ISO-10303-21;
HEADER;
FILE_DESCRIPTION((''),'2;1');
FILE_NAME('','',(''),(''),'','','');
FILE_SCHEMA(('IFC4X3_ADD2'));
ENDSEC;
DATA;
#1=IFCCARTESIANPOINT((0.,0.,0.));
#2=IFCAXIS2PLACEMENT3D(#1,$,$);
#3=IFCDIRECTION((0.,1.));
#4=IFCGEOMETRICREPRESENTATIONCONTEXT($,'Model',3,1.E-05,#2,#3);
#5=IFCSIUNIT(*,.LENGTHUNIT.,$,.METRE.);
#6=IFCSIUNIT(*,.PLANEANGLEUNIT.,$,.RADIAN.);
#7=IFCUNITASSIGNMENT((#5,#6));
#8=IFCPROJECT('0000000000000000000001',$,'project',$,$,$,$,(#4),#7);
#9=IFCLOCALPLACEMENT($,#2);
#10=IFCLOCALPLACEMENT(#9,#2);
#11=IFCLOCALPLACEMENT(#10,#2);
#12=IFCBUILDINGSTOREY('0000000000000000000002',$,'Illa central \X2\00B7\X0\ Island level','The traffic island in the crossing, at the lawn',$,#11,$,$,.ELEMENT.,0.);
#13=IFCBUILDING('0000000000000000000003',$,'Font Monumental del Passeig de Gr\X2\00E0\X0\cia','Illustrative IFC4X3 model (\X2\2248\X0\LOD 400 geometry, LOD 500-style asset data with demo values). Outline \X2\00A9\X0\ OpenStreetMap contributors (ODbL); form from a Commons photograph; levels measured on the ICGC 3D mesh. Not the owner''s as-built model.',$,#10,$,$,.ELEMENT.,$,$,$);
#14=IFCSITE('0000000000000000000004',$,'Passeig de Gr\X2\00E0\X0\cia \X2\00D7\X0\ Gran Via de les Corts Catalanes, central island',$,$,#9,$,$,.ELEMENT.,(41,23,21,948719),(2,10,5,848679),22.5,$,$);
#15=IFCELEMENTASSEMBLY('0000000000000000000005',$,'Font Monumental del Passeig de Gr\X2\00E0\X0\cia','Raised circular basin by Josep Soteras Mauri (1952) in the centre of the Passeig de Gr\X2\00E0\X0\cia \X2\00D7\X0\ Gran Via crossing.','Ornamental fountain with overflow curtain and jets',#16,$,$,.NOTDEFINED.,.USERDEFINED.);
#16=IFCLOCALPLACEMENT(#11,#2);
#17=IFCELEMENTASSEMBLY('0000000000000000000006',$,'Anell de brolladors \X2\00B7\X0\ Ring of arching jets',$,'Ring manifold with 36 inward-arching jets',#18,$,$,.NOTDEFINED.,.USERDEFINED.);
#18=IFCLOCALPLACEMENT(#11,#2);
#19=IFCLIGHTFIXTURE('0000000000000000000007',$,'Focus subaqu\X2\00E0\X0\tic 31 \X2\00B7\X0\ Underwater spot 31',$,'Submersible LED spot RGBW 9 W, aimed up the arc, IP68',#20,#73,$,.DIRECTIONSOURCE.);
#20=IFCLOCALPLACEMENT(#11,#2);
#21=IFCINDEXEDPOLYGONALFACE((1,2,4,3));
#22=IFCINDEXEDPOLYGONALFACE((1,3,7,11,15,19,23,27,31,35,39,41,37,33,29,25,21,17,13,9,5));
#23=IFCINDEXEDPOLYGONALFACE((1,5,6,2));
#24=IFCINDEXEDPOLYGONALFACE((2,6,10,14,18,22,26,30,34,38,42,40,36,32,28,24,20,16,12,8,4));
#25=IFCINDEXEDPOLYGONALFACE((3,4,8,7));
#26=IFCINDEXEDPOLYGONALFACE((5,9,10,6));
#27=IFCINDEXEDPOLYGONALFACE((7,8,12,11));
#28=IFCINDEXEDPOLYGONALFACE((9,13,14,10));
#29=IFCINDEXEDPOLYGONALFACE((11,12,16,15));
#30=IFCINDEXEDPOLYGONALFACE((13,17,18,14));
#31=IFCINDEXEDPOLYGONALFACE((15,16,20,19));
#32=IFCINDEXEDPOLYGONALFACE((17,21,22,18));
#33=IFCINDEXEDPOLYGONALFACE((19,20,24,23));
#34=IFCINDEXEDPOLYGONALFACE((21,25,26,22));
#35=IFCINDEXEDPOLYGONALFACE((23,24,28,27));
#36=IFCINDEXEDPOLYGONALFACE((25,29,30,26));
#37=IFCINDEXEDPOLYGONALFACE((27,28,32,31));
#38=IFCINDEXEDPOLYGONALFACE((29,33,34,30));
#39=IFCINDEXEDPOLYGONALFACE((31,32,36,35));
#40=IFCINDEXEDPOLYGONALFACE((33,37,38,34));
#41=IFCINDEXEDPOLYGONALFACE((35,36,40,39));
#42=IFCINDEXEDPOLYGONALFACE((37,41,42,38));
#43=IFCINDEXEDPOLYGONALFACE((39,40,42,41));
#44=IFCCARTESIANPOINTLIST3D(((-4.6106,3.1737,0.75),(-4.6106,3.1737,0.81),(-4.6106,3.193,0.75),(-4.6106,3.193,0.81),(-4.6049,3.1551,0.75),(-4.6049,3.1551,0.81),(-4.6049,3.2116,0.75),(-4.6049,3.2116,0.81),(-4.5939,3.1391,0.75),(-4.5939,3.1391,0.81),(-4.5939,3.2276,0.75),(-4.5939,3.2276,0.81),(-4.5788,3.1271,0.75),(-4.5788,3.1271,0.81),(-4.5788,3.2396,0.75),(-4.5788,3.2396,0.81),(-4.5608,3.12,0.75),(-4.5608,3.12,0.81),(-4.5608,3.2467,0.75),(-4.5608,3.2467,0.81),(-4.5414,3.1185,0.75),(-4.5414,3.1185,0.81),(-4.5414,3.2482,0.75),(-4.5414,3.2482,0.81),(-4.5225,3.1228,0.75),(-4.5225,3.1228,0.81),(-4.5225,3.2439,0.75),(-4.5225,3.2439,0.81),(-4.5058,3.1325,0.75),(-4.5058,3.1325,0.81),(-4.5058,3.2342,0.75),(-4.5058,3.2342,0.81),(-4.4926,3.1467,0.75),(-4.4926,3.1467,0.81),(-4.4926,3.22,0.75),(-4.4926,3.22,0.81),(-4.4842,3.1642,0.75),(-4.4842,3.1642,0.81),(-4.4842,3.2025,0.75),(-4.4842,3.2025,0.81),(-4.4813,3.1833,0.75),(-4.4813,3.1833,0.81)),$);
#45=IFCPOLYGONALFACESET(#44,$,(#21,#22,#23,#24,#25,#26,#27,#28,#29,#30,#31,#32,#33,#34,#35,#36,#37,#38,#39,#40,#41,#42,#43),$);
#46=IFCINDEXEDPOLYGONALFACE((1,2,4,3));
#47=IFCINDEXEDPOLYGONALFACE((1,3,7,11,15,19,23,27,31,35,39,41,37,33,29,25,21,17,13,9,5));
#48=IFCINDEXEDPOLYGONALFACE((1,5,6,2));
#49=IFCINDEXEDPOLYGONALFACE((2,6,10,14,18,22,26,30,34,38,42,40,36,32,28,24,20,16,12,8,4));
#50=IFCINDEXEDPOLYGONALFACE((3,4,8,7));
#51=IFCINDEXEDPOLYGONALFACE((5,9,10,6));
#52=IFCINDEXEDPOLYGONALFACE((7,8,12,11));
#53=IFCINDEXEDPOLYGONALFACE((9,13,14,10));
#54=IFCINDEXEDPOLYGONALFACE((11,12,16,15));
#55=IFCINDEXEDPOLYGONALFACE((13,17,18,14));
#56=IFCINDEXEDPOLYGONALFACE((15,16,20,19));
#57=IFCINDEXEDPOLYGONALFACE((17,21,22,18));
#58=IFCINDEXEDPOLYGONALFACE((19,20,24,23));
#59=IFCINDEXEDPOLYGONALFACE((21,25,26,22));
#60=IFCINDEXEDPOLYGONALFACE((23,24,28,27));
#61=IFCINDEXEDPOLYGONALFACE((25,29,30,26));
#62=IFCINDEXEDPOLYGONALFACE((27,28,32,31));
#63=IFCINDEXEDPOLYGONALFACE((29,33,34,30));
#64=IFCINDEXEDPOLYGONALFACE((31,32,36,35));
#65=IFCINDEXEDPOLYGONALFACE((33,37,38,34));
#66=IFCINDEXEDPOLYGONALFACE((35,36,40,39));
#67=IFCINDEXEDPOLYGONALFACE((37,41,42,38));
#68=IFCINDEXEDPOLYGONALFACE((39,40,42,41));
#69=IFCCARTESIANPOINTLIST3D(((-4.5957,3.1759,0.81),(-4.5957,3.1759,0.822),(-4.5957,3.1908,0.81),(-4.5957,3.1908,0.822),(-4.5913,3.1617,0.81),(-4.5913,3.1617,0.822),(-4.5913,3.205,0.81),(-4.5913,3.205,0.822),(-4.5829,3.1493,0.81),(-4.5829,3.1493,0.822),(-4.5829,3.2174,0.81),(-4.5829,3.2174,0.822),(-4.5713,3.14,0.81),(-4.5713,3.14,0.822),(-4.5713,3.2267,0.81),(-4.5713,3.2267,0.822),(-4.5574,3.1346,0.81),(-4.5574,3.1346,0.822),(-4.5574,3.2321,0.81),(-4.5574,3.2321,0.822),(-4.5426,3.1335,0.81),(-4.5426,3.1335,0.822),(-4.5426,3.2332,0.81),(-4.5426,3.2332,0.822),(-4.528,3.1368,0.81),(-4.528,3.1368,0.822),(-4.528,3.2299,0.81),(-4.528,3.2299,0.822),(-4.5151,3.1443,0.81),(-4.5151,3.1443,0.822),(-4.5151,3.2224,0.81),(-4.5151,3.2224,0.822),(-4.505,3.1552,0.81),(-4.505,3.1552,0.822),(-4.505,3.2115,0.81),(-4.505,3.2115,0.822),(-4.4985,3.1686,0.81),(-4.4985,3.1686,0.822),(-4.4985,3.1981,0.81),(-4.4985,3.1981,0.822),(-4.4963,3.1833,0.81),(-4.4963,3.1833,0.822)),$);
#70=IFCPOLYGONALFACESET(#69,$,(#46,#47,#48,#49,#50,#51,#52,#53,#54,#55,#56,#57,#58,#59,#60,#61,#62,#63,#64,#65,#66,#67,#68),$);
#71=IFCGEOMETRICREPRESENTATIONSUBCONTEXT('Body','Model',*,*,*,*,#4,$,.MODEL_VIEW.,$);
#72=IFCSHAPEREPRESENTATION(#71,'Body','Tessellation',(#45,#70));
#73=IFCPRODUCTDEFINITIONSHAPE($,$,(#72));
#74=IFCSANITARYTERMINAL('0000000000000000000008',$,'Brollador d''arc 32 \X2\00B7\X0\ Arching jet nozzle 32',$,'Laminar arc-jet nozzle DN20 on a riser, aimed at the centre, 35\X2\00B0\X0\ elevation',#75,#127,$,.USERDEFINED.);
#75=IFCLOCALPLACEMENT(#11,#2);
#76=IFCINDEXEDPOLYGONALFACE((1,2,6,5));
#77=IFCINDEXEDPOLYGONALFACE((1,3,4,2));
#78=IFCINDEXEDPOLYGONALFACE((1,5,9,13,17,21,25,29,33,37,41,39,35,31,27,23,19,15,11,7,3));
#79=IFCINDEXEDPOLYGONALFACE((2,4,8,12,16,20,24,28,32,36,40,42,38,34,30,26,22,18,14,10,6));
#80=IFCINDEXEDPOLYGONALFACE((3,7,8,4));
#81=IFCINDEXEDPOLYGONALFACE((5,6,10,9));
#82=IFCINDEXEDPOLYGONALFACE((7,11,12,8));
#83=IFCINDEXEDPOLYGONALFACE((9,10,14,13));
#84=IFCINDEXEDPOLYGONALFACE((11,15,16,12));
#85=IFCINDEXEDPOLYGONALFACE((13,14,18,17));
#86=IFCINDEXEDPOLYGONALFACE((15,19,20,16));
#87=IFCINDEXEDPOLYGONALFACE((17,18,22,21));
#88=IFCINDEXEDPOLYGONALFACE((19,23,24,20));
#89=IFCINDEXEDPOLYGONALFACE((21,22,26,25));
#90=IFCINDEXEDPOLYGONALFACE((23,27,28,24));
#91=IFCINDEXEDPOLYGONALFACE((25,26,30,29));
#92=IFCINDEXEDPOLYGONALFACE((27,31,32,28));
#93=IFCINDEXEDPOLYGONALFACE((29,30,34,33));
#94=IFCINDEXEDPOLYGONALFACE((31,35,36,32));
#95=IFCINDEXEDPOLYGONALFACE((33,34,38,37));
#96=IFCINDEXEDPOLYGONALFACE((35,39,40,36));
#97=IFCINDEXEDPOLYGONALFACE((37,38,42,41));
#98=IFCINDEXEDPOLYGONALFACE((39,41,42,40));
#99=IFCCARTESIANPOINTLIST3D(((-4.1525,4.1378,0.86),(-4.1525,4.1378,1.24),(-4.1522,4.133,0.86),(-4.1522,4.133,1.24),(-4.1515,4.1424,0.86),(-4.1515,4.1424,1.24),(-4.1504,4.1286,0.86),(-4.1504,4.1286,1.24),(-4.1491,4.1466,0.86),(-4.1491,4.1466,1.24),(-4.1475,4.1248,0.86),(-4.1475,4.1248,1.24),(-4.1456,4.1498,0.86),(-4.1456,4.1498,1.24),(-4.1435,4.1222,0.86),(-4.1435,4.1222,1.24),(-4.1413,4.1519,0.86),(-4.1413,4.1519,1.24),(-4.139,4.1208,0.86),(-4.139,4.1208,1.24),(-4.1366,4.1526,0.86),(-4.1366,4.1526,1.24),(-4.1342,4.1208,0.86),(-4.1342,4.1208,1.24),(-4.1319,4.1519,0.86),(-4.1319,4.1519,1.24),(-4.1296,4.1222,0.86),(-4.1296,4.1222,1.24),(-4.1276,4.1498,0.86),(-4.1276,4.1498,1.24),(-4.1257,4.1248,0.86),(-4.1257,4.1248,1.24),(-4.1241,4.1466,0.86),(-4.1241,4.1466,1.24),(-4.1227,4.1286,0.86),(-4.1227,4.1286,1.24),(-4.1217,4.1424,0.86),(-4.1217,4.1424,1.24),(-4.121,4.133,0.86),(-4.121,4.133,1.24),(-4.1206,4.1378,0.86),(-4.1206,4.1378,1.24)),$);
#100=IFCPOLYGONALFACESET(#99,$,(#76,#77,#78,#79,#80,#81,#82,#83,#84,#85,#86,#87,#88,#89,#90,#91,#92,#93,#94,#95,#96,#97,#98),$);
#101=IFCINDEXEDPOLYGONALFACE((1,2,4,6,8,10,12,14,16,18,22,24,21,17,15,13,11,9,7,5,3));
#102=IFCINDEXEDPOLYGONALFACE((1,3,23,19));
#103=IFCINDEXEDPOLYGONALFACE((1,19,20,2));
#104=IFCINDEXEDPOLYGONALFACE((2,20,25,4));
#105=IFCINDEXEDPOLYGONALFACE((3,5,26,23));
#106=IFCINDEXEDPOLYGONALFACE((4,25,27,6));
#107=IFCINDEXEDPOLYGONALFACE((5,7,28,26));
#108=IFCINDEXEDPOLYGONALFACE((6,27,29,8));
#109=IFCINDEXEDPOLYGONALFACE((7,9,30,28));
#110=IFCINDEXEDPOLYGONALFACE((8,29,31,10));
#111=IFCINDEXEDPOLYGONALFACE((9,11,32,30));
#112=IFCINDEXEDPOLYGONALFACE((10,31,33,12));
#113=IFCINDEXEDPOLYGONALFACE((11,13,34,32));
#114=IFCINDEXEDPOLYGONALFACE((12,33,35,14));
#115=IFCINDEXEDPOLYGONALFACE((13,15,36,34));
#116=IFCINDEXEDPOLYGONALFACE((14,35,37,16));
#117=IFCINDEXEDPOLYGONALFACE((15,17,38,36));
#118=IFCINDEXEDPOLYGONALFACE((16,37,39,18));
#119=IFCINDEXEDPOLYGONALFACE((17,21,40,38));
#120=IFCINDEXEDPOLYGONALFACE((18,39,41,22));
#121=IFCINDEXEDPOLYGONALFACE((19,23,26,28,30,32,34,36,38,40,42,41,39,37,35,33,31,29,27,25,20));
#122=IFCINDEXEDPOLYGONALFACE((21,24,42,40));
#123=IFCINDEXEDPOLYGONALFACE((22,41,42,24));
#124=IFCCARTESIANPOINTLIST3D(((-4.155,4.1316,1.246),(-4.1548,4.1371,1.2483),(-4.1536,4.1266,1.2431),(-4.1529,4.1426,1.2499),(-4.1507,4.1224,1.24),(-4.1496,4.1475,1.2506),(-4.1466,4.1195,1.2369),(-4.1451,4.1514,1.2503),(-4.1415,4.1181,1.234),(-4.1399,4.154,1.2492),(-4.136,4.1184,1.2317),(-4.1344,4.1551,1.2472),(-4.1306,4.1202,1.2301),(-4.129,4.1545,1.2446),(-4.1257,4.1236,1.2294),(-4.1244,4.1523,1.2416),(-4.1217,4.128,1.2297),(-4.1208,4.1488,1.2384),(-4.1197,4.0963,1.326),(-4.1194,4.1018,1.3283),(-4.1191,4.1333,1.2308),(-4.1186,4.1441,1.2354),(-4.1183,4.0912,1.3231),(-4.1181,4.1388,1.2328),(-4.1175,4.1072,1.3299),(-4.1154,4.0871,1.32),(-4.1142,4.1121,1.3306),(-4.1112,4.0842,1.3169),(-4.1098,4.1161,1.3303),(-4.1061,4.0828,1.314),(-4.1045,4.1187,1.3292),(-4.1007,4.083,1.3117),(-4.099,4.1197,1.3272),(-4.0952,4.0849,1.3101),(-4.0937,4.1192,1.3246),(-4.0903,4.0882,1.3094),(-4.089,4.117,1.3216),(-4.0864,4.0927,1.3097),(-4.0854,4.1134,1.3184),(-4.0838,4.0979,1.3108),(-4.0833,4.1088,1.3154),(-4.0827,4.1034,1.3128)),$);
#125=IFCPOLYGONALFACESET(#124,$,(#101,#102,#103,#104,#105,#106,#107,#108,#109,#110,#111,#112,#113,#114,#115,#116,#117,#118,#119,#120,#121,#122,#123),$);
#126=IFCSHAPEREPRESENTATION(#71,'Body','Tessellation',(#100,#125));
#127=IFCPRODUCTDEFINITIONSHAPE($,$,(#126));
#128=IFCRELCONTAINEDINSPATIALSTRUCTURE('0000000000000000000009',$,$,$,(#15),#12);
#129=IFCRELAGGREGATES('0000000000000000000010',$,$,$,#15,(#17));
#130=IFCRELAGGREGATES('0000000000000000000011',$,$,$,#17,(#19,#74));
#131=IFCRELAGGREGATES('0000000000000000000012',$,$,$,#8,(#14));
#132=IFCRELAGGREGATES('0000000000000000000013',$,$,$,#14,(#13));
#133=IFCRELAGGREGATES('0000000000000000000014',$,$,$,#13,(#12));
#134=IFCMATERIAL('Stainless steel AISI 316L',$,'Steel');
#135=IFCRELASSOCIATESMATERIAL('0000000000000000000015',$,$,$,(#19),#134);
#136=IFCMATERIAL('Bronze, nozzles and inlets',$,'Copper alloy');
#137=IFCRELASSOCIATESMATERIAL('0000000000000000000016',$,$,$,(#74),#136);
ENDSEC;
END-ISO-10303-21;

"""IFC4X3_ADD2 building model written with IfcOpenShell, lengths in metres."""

from ifc_helpers import new_model, si_unit, direction, frame, origin, origin_2d_with_axis, place, context, subcontext, project, spatial, circle, extrude, material, element, aggregate, save


model = new_model("IFC4X3_ADD2")

# Units and contexts
model_context = context("Model", 3, precision=1e-05, world=origin(), true_north=direction((0.0, 1.0)))
body_context = subcontext(model_context, "Body", "Model", "MODEL_VIEW")
ifc_project = project(units=[si_unit("LENGTHUNIT", "METRE"), si_unit("PLANEANGLEUNIT", "RADIAN")], contexts=[model_context])

# Site, building, storey
site_placement = place(None, origin())
site = spatial("IfcSite", under=ifc_project, at=site_placement, Name="Passeig de Gràcia × Gran Via de les Corts Catalanes, central island", CompositionType="ELEMENT", RefLatitude=(41, 23, 21, 948719), RefLongitude=(2, 10, 5, 848679), RefElevation=22.5)
building_placement = place(site_placement, origin())
building = spatial("IfcBuilding", under=site, at=building_placement, Name="Font Monumental del Passeig de Gràcia", Description="Illustrative IFC4X3 model (≈LOD 400 geometry, LOD 500-style asset data with demo values). Outline © OpenStreetMap contributors (ODbL); form from a Commons photograph; levels measured on the ICGC 3D mesh. Not the owner's as-built model.", CompositionType="ELEMENT")
storey_placement = place(building_placement, origin())
storey = spatial("IfcBuildingStorey", under=building, at=storey_placement, Name="Illa central · Island level", Description="The traffic island in the crossing, at the lawn", CompositionType="ELEMENT", Elevation=0.0)

# Element assemblies, light fixture, sanitary terminal
assembly_1_placement = place(building_placement, origin())
assembly_1 = element("IfcElementAssembly", 1, at=assembly_1_placement, inside=storey, Name="Font Monumental del Passeig de Gràcia", Description="Raised circular basin by Josep Soteras Mauri (1952) in the centre of the Passeig de Gràcia × Gran Via crossing.", ObjectType="Ornamental fountain with overflow curtain and jets", AssemblyPlace="NOTDEFINED", PredefinedType="USERDEFINED")
assembly_2_placement = place(building_placement, origin())
assembly_2 = element("IfcElementAssembly", 2, at=assembly_2_placement, Name="Anell de brolladors · Ring of arching jets", ObjectType="Ring manifold with 36 inward-arching jets", AssemblyPlace="NOTDEFINED", PredefinedType="USERDEFINED")
aggregate(assembly_1, [assembly_2])
ifc_material_1 = material(Name="Stainless steel AISI 316L", Category="Steel")
ifc_material_2 = material(Name="Bronze, nozzles and inlets", Category="Copper alloy")
light_fixture_1_placement = place(building_placement, origin())
light_fixture_1 = element("IfcLightFixture", 3, at=light_fixture_1_placement, material=ifc_material_1, Name="Focus subaquàtic 31 · Underwater spot 31", ObjectType="Submersible LED spot RGBW 9 W, aimed up the arc, IP68", PredefinedType="DIRECTIONSOURCE", context=body_context, shape_type="SweptSolid", body=[
    extrude(circle(Radius=0.065, at=origin_2d_with_axis()), frame((-4.5463, 3.1833, 0.75)), (0.0, 0.0, 1.0), 0.06),
    extrude(circle(Radius=0.05, at=origin_2d_with_axis()), frame((-4.5463, 3.1833, 0.81)), (0.0, 0.0, 1.0), 0.012),
])
sanitary_terminal_1_placement = place(building_placement, origin())
sanitary_terminal_1 = element("IfcSanitaryTerminal", 4, at=sanitary_terminal_1_placement, material=ifc_material_2, Name="Brollador d'arc 32 · Arching jet nozzle 32", ObjectType="Laminar arc-jet nozzle DN20 on a riser, aimed at the centre, 35° elevation", PredefinedType="USERDEFINED", context=body_context, shape_type="SweptSolid", body=[
    extrude(circle(Radius=0.016, at=origin_2d_with_axis()), frame((-4.1366, 4.1366, 0.86), z_axis=(0.0, 0.0, 1.0), x_axis=(0.0, 1.0, 0.0)), (0.0, 0.0, 1.0), 0.38),
    extrude(circle(Radius=0.02, at=origin_2d_with_axis()), frame((-4.1366, 4.1366, 1.24), z_axis=(0.374766, -0.374766, 0.847998), x_axis=(-0.707107, -0.707107, 0.0)), (0.0, 0.0, 1.0), 0.0943),
])
aggregate(assembly_2, [light_fixture_1, sanitary_terminal_1])

save(model, "model.ifc")
